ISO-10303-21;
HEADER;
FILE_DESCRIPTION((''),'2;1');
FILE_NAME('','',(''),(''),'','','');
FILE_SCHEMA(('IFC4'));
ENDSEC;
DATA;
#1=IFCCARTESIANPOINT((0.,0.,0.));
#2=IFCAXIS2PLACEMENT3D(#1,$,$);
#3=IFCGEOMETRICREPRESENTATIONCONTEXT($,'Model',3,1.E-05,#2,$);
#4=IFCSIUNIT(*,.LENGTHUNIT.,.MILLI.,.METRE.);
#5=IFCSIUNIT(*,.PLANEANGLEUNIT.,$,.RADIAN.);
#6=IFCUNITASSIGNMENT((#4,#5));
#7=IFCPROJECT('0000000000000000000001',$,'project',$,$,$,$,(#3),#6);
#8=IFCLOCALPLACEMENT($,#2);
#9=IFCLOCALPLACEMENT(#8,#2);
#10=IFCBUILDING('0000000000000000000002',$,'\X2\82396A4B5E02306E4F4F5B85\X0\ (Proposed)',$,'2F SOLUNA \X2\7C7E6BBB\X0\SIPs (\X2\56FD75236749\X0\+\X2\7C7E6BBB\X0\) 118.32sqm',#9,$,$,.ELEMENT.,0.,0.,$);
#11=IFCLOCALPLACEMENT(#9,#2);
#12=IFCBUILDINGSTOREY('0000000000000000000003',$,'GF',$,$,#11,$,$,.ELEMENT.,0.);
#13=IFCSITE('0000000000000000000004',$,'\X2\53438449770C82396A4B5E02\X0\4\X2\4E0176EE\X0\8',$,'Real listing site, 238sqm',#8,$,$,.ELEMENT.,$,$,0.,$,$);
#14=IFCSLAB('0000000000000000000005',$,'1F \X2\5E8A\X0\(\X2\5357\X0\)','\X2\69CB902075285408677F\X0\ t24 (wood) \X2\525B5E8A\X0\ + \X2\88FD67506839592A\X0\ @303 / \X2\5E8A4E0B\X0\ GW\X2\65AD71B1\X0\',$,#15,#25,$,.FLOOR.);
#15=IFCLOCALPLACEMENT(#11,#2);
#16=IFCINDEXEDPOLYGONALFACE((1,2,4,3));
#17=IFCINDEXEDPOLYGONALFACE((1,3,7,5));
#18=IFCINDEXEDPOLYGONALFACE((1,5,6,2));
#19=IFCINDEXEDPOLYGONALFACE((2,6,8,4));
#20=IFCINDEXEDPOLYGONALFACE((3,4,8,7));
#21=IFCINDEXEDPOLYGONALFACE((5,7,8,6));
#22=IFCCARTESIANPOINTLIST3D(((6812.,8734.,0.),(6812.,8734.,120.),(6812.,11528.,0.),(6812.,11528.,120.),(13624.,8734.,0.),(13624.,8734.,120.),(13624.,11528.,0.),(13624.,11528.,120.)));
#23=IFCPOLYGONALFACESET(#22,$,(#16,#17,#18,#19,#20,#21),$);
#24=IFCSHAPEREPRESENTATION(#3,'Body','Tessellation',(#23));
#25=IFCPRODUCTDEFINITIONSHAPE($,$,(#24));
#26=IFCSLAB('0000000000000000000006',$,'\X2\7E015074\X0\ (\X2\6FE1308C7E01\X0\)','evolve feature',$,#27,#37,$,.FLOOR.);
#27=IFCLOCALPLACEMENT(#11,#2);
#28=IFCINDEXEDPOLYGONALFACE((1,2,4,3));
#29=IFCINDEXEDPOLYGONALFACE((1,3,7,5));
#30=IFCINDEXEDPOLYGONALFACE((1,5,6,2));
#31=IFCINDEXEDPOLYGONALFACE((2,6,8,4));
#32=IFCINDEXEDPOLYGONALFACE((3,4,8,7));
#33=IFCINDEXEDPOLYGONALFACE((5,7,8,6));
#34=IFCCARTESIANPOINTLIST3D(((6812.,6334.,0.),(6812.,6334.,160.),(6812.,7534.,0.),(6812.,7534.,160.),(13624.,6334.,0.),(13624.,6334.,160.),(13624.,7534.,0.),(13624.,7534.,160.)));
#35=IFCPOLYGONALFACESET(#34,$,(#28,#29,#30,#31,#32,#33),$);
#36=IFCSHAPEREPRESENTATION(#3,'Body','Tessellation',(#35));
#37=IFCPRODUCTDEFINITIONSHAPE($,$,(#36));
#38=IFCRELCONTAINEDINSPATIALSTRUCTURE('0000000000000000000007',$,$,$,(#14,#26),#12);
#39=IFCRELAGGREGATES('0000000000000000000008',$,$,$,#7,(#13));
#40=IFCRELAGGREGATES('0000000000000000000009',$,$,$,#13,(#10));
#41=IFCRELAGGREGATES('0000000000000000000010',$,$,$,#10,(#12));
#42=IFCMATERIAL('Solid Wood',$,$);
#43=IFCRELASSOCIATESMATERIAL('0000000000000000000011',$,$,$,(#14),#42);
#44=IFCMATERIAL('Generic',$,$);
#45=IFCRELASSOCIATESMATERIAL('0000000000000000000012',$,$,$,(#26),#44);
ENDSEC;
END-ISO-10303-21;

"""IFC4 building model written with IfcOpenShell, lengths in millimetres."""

from ifc_helpers import new_model, si_unit, frame, frame_2d, origin, place, context, project, spatial, rectangle, extrude, material, element, save


model = new_model("IFC4")

# Units and contexts
model_context = context("Model", 3, precision=1e-05, world=origin())
ifc_project = project(units=[si_unit("LENGTHUNIT", "METRE", prefix="MILLI"), si_unit("PLANEANGLEUNIT", "RADIAN")], contexts=[model_context])

# Site, building, storey
site_placement = place(None, origin())
site = spatial("IfcSite", under=ifc_project, at=site_placement, Name="千葉県船橋市4丁目8", ObjectType="Real listing site, 238sqm", CompositionType="ELEMENT", RefElevation=0.0)
building_placement = place(site_placement, origin())
building = spatial("IfcBuilding", under=site, at=building_placement, Name="船橋市の住宅 (Proposed)", ObjectType="2F SOLUNA 籾殻SIPs (国産杉+籾殻) 118.32sqm", CompositionType="ELEMENT", ElevationOfRefHeight=0.0, ElevationOfTerrain=0.0)
storey_placement = place(building_placement, origin())
storey = spatial("IfcBuildingStorey", under=building, at=storey_placement, Name="GF", CompositionType="ELEMENT", Elevation=0.0)

# Slabs
ifc_material_1 = material(Name="Solid Wood")
slab_1_placement = place(storey_placement, frame((3406.0, 4367.0, 0.0)))
element("IfcSlab", 1, at=slab_1_placement, inside=storey, material=ifc_material_1, Name="1F 床(南)", Description="構造用合板 t24 (wood) 剛床 + 製材根太 @303 / 床下 GW断熱", PredefinedType="FLOOR", context=model_context, shape_type="SweptSolid", body=[
    extrude(rectangle(XDim=6812.0, YDim=2794.0, at=frame_2d((3406.0, 1397.0))), frame((3406.0, 4367.0, 0.0)), (0.0, 0.0, 1.0), 120.0),
])
ifc_material_2 = material(Name="Generic")
slab_2_placement = place(storey_placement, frame((3406.0, 3167.0, 0.0)))
element("IfcSlab", 2, at=slab_2_placement, inside=storey, material=ifc_material_2, Name="縁側 (濡れ縁)", Description="evolve feature", PredefinedType="FLOOR", context=model_context, shape_type="SweptSolid", body=[
    extrude(rectangle(XDim=6812.0, YDim=1200.0, at=frame_2d((3406.0, 600.0))), frame((3406.0, 3167.0, 0.0)), (0.0, 0.0, 1.0), 160.0),
])

save(model, "model.ifc")
